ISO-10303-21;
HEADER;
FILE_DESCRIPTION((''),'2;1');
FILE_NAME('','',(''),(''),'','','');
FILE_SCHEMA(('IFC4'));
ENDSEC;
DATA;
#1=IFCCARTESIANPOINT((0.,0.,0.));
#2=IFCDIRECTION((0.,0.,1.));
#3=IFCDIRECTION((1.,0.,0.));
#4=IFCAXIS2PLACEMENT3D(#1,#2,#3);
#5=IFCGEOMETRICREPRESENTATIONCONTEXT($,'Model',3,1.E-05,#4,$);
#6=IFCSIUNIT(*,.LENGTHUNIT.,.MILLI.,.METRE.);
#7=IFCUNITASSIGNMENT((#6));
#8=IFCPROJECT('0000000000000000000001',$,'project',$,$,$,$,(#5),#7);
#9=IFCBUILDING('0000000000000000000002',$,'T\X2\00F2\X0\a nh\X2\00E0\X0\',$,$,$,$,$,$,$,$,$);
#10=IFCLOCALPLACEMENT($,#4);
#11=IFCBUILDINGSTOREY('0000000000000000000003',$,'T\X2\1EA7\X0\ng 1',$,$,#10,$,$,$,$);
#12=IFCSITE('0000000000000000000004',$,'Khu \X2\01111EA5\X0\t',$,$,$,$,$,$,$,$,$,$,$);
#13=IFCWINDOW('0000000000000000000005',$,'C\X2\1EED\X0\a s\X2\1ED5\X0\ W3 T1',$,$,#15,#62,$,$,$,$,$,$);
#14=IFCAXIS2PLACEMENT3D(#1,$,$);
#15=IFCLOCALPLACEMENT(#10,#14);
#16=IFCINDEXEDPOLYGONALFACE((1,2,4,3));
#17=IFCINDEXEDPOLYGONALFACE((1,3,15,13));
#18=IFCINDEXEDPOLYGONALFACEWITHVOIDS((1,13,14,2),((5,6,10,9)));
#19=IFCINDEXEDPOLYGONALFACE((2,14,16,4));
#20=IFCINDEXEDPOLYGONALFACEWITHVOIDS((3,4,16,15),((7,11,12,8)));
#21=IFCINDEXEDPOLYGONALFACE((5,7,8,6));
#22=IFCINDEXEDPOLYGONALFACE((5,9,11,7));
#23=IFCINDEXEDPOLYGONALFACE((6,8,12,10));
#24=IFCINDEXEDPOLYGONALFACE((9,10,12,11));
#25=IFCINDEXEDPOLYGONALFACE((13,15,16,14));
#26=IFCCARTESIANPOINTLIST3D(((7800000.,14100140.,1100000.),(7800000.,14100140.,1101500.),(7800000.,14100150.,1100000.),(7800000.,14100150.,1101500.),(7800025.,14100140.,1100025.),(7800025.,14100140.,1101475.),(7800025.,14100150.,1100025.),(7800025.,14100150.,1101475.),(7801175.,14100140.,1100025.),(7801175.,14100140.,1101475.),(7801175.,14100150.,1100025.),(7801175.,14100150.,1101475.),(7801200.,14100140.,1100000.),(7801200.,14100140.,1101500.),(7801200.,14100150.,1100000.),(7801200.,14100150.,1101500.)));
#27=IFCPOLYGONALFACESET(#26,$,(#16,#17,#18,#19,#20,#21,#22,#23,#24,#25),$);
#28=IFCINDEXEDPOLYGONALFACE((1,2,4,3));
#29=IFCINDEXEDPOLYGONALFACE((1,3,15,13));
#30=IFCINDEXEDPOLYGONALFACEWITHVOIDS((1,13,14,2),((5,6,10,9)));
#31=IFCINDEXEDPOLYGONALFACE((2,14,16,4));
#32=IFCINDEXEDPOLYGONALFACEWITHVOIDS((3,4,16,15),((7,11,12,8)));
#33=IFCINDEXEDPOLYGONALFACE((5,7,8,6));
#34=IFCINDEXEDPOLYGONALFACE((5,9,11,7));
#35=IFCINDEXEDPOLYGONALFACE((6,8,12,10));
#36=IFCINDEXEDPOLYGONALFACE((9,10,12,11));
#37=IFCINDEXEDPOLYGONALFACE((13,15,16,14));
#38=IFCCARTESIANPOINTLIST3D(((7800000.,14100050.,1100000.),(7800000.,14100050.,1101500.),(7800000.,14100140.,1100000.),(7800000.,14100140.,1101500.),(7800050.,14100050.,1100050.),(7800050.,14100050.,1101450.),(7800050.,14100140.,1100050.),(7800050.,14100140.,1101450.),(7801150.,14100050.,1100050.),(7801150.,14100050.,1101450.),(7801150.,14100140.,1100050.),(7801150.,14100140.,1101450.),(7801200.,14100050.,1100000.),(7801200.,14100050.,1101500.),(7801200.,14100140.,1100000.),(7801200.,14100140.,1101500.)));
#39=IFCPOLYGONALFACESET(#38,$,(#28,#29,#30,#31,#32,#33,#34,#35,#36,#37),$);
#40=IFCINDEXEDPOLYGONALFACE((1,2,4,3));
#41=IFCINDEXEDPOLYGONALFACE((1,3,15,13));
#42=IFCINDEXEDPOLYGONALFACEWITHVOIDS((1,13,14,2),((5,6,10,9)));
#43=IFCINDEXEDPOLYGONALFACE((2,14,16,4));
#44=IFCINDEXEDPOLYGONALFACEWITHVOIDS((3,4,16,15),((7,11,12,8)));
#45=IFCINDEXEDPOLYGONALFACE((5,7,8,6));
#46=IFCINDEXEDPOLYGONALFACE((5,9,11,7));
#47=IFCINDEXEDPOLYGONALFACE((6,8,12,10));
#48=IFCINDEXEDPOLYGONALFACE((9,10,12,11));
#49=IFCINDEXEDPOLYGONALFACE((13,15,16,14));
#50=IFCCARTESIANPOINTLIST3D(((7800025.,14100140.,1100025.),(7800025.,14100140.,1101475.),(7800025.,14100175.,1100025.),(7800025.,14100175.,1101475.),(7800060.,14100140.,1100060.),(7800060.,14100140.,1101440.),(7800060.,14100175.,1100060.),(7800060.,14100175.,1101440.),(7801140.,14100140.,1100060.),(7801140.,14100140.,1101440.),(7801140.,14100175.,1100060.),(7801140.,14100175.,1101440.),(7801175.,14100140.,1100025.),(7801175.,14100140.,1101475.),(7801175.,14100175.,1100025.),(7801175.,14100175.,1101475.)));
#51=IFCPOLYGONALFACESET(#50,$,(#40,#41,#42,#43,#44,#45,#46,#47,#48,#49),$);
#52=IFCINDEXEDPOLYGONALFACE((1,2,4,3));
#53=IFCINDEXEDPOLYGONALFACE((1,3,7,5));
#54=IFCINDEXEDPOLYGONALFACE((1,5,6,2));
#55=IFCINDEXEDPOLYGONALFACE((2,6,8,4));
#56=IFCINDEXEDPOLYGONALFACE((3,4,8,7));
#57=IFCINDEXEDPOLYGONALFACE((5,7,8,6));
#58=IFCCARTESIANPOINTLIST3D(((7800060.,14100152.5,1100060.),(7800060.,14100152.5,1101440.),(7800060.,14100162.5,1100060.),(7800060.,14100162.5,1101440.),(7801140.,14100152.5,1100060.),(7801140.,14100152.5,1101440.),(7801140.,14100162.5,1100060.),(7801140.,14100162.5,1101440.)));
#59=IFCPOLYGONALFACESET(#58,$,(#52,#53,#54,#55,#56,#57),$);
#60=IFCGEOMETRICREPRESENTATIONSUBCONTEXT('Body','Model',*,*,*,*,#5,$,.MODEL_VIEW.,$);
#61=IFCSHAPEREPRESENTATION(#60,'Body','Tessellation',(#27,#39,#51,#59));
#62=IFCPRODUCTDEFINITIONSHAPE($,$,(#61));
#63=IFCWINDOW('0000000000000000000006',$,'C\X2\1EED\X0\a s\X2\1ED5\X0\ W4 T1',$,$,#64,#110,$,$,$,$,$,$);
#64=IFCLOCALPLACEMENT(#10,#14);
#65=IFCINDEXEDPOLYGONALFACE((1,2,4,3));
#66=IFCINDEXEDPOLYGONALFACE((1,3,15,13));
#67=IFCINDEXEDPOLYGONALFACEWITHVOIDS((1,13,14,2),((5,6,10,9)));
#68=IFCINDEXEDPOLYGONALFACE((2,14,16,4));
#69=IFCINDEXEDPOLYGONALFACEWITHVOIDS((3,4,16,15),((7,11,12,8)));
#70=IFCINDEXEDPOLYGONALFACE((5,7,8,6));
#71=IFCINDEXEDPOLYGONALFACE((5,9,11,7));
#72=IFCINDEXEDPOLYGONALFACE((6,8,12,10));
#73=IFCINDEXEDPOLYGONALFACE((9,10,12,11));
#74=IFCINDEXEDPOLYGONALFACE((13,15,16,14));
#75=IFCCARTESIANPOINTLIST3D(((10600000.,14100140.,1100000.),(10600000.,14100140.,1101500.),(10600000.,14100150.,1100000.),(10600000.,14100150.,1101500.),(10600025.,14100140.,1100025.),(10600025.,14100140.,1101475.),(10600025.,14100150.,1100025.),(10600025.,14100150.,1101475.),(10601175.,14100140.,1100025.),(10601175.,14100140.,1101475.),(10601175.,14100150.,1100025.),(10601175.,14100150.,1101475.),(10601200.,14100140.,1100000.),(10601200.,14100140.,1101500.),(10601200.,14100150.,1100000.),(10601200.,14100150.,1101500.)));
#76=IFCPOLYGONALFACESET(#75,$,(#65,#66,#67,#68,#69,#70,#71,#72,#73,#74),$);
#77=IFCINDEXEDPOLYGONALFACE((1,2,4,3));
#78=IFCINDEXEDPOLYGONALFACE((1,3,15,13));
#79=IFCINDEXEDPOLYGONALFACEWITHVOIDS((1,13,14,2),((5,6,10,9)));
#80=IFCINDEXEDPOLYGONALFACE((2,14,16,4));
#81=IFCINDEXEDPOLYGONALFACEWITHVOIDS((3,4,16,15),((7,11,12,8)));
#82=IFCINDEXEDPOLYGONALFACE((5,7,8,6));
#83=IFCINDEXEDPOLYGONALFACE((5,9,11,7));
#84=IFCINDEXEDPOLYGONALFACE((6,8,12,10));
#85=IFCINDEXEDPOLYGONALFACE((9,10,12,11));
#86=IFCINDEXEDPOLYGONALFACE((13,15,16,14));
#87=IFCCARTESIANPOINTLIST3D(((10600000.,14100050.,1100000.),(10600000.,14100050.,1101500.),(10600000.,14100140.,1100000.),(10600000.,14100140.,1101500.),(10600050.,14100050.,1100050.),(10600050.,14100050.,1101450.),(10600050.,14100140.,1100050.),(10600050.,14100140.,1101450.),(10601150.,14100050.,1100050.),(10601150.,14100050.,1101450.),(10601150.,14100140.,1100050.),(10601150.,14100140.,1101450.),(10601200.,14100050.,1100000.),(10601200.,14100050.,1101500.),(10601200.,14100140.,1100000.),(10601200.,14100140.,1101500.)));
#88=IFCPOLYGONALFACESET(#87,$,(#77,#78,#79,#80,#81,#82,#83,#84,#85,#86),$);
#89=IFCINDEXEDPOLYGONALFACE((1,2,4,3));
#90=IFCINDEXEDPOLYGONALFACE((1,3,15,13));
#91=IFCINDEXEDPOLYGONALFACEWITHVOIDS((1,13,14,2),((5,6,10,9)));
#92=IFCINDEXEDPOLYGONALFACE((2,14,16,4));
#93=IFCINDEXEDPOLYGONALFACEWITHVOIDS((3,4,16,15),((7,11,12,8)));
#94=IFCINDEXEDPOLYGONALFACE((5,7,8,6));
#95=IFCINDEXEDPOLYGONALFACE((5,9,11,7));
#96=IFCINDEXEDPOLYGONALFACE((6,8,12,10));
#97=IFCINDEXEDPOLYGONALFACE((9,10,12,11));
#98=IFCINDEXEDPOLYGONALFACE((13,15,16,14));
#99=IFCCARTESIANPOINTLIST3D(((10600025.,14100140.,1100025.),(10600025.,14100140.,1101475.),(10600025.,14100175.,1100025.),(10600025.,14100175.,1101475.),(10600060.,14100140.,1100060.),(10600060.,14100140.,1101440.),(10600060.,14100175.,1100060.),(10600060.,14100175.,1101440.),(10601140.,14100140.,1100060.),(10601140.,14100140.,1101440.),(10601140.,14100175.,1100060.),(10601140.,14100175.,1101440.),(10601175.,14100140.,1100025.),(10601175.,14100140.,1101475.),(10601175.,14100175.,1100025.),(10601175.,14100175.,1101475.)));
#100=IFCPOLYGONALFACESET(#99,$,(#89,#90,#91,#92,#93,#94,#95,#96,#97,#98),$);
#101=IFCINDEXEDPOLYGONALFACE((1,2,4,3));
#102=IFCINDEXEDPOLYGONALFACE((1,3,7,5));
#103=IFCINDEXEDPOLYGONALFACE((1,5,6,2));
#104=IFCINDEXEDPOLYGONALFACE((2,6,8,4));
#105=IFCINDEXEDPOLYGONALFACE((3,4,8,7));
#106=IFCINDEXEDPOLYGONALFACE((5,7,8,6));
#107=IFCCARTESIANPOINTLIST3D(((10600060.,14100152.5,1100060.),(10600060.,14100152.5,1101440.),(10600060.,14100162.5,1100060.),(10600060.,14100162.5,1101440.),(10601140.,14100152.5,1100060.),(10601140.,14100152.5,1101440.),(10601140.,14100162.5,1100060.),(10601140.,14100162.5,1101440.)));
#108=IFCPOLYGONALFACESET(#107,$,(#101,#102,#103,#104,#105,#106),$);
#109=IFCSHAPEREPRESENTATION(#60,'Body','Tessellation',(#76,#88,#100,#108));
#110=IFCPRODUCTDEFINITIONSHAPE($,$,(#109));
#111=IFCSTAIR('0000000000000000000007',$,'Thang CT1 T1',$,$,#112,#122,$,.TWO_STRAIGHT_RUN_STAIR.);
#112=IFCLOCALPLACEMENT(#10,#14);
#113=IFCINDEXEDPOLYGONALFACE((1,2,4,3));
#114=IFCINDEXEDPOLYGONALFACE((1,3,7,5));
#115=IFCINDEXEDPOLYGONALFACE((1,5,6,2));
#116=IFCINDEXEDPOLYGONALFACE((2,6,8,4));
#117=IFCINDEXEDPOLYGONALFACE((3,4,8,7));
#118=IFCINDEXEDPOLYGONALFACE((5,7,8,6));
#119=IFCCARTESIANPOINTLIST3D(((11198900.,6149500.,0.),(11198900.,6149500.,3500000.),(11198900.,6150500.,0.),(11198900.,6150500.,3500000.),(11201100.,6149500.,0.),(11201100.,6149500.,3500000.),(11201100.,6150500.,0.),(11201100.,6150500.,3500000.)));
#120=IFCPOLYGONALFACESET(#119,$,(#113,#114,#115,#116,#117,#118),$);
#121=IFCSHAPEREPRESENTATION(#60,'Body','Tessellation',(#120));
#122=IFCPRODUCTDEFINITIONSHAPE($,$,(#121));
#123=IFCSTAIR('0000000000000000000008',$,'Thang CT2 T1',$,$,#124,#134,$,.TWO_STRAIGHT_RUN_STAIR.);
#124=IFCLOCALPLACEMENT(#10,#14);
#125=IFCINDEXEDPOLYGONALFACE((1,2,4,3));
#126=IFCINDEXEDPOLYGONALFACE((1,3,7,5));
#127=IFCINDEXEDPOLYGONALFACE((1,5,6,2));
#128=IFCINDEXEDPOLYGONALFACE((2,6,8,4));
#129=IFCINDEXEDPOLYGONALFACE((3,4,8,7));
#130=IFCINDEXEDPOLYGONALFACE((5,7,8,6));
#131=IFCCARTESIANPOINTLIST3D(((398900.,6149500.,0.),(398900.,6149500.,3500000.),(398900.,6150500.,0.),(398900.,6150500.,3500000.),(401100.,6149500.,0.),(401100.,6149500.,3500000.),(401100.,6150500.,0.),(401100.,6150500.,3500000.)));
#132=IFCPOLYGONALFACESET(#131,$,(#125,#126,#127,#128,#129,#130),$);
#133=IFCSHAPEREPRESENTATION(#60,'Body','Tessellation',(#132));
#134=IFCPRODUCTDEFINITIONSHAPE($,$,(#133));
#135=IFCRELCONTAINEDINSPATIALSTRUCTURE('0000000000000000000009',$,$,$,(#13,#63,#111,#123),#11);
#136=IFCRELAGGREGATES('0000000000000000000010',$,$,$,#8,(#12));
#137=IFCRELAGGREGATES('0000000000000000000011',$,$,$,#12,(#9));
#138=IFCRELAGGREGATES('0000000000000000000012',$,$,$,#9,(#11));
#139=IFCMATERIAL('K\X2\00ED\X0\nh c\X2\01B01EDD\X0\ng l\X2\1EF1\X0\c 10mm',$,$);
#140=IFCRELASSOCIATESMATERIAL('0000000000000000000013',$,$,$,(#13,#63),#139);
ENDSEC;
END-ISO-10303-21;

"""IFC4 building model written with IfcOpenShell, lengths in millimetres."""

from ifc_helpers import new_model, entity, si_unit, frame, origin_with_axes, place, context, subcontext, project, spatial, line, indexed_curve, outline, extrude, material, element, save


model = new_model("IFC4")

# Units and contexts
model_context = context("Model", 3, precision=1e-05, world=origin_with_axes())
body_context = subcontext(model_context, "Body", "Model", "MODEL_VIEW")
ifc_project = project(units=[si_unit("LENGTHUNIT", "METRE", prefix="MILLI")], contexts=[model_context])

# Site, building, storey
site = spatial("IfcSite", under=ifc_project, Name="Khu đất")
building = spatial("IfcBuilding", under=site, Name="Tòa nhà")
storey_placement = place(None, origin_with_axes())
storey = spatial("IfcBuildingStorey", under=building, at=storey_placement, Name="Tầng 1")

# Windows
ifc_material_1 = material(Name="Kính cường lực 10mm")
for number, where, z_axis, x_axis, name in (
    (1, (7800000.0, 14100000.0, 1100000.0), (0.0, 0.0, 1.0), (1.0, 0.0, 0.0), "Cửa sổ W3 T1"),
    (2, (10600000.0, 14100000.0, 1100000.0), (0.0, 0.0, 1.0), (1.0, 0.0, 0.0), "Cửa sổ W4 T1"),
):
    element("IfcWindow", number, at=place(storey_placement, frame(where, z_axis=z_axis, x_axis=x_axis)), inside=storey, material=ifc_material_1, Name=name, context=body_context, shape_type="SolidModel", body=[
        extrude(outline(indexed_curve([(0.0, 0.0), (1200.0, 0.0), (1200.0, 1500.0), (0.0, 1500.0)], segments=[line(1, 2, 3, 4, 1)]), holes=[indexed_curve([(25.0, 25.0), (1175.0, 25.0), (1175.0, 1475.0), (25.0, 1475.0)], segments=[line(1, 2, 3, 4, 1)])]), frame((0.0, 140.0, 0.0), z_axis=(0.0, -1.0, 0.0), x_axis=(1.0, 0.0, 0.0)), (0.0, 0.0, -1.0), 10.0),
        extrude(outline(indexed_curve([(0.0, 0.0), (1200.0, 0.0), (1200.0, 1500.0), (0.0, 1500.0)], segments=[line(1, 2, 3, 4, 1)]), holes=[indexed_curve([(50.0, 50.0), (1150.0, 50.0), (1150.0, 1450.0), (50.0, 1450.0)], segments=[line(1, 2, 3, 4, 1)])]), frame((0.0, 50.0, 0.0), z_axis=(0.0, -1.0, 0.0), x_axis=(1.0, 0.0, 0.0)), (0.0, 0.0, -1.0), 90.0),
        extrude(outline(indexed_curve([(0.0, 0.0), (1150.0, 0.0), (1150.0, 1450.0), (0.0, 1450.0)], segments=[line(1, 2, 3, 4, 1)]), holes=[indexed_curve([(35.0, 35.0), (1115.0, 35.0), (1115.0, 1415.0), (35.0, 1415.0)], segments=[line(1, 2, 3, 4, 1)])]), frame((25.0, 140.0, 25.0), z_axis=(0.0, -1.0, 0.0), x_axis=(1.0, 0.0, 0.0)), (0.0, 0.0, -1.0), 35.0),
        extrude(outline(indexed_curve([(35.0, 35.0), (1115.0, 35.0), (1115.0, 1415.0), (35.0, 1415.0)], segments=[line(1, 2, 3, 4, 1)])), frame((25.0, 152.5, 25.0), z_axis=(0.0, -1.0, 0.0), x_axis=(1.0, 0.0, 0.0)), (0.0, 0.0, -1.0), 10.0),
    ])

# Stairs
for number, where, z_axis, x_axis, name in (
    (3, (11200000.0, 6150000.0, 0.0), (0.0, 0.0, 1.0), (1.0, 0.0, 0.0), "Thang CT1 T1"),
    (4, (400000.0, 6150000.0, 0.0), (0.0, 0.0, 1.0), (1.0, 0.0, 0.0), "Thang CT2 T1"),
):
    element("IfcStair", number, at=place(storey_placement, frame(where, z_axis=z_axis, x_axis=x_axis)), inside=storey, Name=name, PredefinedType="TWO_STRAIGHT_RUN_STAIR", context=body_context, shape_type="SweptSolid", body=[
        extrude(entity("IfcRectangleProfileDef", None, None, None, 2200.0, 1000.0), origin_with_axes(), (0.0, 0.0, 1.0), 3500000.0),
    ])

save(model, "model.ifc")
